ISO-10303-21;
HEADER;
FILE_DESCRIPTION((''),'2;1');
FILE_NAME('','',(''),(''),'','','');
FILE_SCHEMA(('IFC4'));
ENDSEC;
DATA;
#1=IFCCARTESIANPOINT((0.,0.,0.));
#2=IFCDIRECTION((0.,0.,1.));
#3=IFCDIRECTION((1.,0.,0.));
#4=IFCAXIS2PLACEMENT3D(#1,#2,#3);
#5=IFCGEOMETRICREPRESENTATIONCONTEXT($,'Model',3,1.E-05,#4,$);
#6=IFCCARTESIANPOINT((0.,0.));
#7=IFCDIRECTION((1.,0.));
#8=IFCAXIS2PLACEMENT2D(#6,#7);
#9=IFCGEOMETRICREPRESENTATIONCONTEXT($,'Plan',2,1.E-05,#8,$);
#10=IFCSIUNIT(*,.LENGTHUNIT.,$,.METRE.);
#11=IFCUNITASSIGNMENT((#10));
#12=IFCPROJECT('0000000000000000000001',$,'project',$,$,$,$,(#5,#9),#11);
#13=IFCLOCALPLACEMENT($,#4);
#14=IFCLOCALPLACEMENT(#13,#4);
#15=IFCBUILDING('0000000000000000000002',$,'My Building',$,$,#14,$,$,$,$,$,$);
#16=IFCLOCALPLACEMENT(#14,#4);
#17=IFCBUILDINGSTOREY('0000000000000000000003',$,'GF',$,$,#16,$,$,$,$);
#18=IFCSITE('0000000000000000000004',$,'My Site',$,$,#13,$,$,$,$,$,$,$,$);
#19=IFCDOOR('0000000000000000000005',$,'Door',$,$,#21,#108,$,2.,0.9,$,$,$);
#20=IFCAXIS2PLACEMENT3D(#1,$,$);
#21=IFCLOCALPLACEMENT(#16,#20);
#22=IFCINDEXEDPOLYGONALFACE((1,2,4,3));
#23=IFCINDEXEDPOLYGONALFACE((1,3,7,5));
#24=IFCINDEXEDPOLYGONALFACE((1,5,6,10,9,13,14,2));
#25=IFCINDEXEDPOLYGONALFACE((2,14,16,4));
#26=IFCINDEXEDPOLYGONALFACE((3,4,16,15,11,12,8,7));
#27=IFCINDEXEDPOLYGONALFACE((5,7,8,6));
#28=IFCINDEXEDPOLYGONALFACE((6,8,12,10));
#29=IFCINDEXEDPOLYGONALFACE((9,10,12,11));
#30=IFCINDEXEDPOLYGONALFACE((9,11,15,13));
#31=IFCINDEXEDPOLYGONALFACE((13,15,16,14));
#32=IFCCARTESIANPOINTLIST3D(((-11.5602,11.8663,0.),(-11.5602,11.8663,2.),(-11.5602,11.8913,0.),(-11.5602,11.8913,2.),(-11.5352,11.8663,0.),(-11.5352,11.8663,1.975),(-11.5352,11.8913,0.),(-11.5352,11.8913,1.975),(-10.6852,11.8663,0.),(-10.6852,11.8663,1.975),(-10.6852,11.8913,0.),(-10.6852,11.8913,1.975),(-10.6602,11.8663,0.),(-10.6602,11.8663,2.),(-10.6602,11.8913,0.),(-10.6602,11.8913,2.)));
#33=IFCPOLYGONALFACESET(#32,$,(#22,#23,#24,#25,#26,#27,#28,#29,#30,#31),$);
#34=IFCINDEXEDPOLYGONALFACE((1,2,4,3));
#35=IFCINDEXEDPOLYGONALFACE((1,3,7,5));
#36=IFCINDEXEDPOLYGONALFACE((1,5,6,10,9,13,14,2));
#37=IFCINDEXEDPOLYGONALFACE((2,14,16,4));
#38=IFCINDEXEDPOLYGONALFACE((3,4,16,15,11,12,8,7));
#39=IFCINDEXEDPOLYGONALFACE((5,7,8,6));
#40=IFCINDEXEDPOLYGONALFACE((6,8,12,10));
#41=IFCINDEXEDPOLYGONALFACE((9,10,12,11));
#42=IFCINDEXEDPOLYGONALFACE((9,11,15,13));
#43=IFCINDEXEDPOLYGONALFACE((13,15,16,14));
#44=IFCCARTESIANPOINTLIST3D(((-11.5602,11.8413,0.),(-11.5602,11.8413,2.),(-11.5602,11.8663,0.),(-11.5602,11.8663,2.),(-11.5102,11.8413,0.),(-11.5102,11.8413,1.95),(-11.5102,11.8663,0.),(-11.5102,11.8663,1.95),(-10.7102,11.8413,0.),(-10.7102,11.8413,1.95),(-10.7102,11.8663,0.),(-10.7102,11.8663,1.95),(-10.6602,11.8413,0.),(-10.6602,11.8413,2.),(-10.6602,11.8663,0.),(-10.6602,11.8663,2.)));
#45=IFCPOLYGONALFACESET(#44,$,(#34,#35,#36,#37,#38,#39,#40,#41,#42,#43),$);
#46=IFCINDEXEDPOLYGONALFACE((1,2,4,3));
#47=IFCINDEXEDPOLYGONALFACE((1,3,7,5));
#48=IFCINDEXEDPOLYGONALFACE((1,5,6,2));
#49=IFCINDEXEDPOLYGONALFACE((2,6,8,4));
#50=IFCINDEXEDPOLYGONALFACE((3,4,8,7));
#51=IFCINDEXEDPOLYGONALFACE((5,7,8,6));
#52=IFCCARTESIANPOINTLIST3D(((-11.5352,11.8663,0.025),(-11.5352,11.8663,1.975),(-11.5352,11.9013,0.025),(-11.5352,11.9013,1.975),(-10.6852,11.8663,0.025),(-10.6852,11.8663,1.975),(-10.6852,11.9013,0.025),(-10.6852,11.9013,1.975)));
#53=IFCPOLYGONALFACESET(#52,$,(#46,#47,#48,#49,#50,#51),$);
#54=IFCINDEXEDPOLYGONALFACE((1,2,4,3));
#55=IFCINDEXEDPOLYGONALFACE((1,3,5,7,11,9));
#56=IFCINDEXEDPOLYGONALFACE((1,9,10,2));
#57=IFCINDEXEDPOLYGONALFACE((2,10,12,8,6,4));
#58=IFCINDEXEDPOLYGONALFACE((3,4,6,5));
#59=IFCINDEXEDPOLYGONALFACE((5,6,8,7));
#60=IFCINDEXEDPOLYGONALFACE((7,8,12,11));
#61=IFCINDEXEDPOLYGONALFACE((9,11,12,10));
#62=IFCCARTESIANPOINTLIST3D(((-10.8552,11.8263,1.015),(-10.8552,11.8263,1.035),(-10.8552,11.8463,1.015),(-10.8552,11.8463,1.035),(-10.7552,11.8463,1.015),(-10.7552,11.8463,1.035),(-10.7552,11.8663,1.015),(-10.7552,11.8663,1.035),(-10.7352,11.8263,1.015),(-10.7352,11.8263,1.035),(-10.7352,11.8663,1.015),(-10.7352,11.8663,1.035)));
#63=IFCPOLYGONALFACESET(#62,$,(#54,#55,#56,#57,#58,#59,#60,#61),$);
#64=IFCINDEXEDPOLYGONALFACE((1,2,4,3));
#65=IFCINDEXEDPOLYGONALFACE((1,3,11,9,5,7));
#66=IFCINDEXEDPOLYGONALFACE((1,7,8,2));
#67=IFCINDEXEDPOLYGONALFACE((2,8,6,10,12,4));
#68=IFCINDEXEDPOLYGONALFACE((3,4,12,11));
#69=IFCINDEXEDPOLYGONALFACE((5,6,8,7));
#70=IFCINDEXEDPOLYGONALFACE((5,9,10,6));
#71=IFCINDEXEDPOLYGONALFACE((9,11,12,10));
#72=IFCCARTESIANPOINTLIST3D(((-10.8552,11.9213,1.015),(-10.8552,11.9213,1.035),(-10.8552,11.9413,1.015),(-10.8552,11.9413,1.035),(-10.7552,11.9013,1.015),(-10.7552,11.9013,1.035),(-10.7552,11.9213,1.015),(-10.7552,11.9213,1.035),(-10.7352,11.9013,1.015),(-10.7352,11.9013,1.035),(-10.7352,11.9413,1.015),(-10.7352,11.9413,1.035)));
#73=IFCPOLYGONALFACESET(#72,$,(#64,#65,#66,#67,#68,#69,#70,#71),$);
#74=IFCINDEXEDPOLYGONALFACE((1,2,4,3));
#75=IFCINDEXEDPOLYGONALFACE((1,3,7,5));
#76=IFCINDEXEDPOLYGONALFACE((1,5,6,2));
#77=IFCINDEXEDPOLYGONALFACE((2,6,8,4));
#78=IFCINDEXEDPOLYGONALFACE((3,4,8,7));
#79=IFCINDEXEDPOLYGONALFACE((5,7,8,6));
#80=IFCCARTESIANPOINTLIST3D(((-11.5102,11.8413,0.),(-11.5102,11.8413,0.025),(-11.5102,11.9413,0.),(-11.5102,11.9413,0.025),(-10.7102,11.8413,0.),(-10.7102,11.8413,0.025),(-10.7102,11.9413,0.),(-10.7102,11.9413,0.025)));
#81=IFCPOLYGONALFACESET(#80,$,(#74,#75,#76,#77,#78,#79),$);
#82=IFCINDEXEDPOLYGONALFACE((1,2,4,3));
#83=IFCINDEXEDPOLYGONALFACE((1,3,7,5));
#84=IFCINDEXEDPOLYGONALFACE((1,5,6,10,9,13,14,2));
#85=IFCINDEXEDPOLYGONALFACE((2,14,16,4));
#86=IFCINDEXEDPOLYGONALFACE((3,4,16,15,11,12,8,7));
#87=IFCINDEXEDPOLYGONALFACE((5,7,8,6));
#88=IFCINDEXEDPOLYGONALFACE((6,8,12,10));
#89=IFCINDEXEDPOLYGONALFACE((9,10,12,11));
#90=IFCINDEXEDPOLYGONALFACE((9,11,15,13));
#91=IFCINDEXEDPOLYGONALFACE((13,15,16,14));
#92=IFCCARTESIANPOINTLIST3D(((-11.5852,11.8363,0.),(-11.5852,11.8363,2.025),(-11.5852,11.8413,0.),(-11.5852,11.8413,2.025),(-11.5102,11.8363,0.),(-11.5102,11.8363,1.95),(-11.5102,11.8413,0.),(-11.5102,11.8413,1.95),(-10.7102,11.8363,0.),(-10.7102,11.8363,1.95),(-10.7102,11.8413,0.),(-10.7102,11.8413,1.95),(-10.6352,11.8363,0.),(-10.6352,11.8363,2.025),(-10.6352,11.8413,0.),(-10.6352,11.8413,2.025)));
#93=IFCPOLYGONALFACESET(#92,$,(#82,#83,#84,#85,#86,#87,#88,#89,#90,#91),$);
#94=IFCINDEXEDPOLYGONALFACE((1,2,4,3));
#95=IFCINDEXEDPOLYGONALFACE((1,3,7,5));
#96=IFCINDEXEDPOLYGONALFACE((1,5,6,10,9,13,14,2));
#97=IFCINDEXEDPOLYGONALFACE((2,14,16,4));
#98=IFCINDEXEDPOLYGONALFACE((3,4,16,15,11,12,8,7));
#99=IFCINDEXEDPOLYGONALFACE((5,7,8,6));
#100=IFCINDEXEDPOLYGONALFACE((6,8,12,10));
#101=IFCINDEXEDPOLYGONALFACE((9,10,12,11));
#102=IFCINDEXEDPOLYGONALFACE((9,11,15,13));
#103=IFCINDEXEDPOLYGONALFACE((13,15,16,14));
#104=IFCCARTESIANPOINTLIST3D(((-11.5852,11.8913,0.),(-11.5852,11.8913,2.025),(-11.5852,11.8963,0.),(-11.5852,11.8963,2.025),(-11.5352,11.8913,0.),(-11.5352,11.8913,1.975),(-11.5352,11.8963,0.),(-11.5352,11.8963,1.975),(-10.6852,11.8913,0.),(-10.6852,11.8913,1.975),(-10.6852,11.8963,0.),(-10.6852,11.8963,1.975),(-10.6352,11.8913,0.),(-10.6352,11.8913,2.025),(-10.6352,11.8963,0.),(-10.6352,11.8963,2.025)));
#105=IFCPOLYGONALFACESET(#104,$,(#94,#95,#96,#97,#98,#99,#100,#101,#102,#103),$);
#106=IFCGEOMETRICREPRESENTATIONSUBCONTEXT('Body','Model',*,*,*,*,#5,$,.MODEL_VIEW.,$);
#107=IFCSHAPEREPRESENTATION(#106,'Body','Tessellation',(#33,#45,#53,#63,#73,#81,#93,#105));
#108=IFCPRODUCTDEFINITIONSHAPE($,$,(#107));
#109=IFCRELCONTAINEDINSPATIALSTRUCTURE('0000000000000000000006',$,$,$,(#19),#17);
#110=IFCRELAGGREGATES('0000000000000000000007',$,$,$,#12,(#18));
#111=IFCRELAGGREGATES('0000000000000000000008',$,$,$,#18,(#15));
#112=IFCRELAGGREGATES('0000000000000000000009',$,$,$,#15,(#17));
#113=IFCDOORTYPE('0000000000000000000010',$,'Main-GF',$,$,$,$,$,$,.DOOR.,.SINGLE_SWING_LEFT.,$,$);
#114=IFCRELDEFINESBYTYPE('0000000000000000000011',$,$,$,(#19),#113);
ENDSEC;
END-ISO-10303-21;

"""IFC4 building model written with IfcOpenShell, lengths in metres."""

from ifc_helpers import new_model, entity, si_unit, frame, origin_with_axes, origin_2d_with_axis, place, context, subcontext, project, spatial, line, indexed_curve, outline, extrude, shape, source, transform, mapped, type_object, type_shapes, element, save


model = new_model("IFC4")

# Units and contexts
model_context = context("Model", 3, precision=1e-05, world=origin_with_axes())
plan_context = context("Plan", 2, precision=1e-05, world=origin_2d_with_axis())
body_context_1 = subcontext(model_context, "Body", "Model", "MODEL_VIEW")
body_context_2 = subcontext(plan_context, "Body", "Plan", "PLAN_VIEW")
ifc_project = project(units=[si_unit("LENGTHUNIT", "METRE")], contexts=[model_context, plan_context])

# Site, building, storey
site_placement = place(None, origin_with_axes())
site = spatial("IfcSite", under=ifc_project, at=site_placement, Name="My Site")
building_placement = place(site_placement, origin_with_axes())
building = spatial("IfcBuilding", under=site, at=building_placement, Name="My Building")
storey_placement = place(building_placement, origin_with_axes())
storey = spatial("IfcBuildingStorey", under=building, at=storey_placement, Name="GF")

# Door
door_type_1 = type_object("IfcDoorType", Name="Main-GF", OperationType="SINGLE_SWING_LEFT", PredefinedType="DOOR")
shared_shape_1 = source(origin_with_axes(), body_context_1, "Body", "SweptSolid", [
    extrude(outline(indexed_curve([(0.0, 0.0), (0.0, 2.0), (0.9, 2.0), (0.9, 0.0), (0.875, 0.0), (0.875, 1.975), (0.025, 1.975), (0.025, 0.0)], segments=[line(1, 2, 3, 4, 5, 6, 7, 8, 1)])), frame((0.0, 0.025, 0.0), z_axis=(0.0, -1.0, 0.0), x_axis=(1.0, 0.0, 0.0)), (0.0, 0.0, -1.0), 0.025),
    extrude(outline(indexed_curve([(0.0, 0.0), (0.0, 2.0), (0.9, 2.0), (0.9, 0.0), (0.85, 0.0), (0.85, 1.95), (0.05, 1.95), (0.05, 0.0)], segments=[line(1, 2, 3, 4, 5, 6, 7, 8, 1)])), frame((0.0, 0.0, 0.0), z_axis=(0.0, -1.0, 0.0), x_axis=(1.0, 0.0, 0.0)), (0.0, 0.0, -1.0), 0.025),
    extrude(outline(indexed_curve([(0.0, 0.0), (0.85, 0.0), (0.85, 0.035), (0.0, 0.035)], segments=[line(1, 2, 3, 4, 1)])), frame((0.025, 0.025, 0.025), z_axis=(0.0, 0.0, 1.0), x_axis=(1.0, 0.0, 0.0)), (0.0, 0.0, 1.0), 1.95),
    extrude(outline(indexed_curve([(0.0, 0.0), (0.0, -0.04), (-0.12, -0.04), (-0.12, -0.02), (-0.02, -0.02), (-0.02, 0.0)], segments=[line(1, 2, 3, 4, 5, 6, 1)])), frame((0.825, 0.025, 1.015), z_axis=(0.0, 0.0, 1.0), x_axis=(1.0, 0.0, 0.0)), (0.0, 0.0, 1.0), 0.02),
    extrude(outline(indexed_curve([(0.0, 0.0), (0.0, 0.04), (-0.12, 0.04), (-0.12, 0.02), (-0.02, 0.02), (-0.02, 0.0)], segments=[line(1, 2, 3, 4, 5, 6, 1)])), frame((0.825, 0.06, 1.015), z_axis=(0.0, 0.0, 1.0), x_axis=(1.0, 0.0, 0.0)), (0.0, 0.0, 1.0), 0.02),
    extrude(outline(indexed_curve([(0.0, 0.0), (0.8, 0.0), (0.8, 0.1), (0.0, 0.1)], segments=[line(1, 2, 3, 4, 1)])), frame((0.05, 0.0, 0.0), z_axis=(0.0, 0.0, 1.0), x_axis=(1.0, 0.0, 0.0)), (0.0, 0.0, 1.0), 0.025),
    extrude(outline(indexed_curve([(0.0, 0.0), (0.0, 2.025), (0.95, 2.025), (0.95, 0.0), (0.875, 0.0), (0.875, 1.95), (0.075, 1.95), (0.075, 0.0)], segments=[line(1, 2, 3, 4, 5, 6, 7, 8, 1)])), frame((-0.025, -0.005, 0.0), z_axis=(0.0, -1.0, 0.0), x_axis=(1.0, 0.0, 0.0)), (0.0, 0.0, -1.0), 0.005),
    extrude(outline(indexed_curve([(0.0, 0.0), (0.0, 2.025), (0.95, 2.025), (0.95, 0.0), (0.9, 0.0), (0.9, 1.975), (0.05, 1.975), (0.05, 0.0)], segments=[line(1, 2, 3, 4, 5, 6, 7, 8, 1)])), frame((-0.025, 0.05, 0.0), z_axis=(0.0, -1.0, 0.0), x_axis=(1.0, 0.0, 0.0)), (0.0, 0.0, -1.0), 0.005),
])
shared_shape_2 = source(origin_with_axes(), body_context_2, "Body", "Curve2D", [
    entity("IfcIndexedPolyCurve", entity("IfcCartesianPointList2D", [[0.0, 0.0], [0.0, 0.05], [0.025, 0.05], [0.025, 0.025], [0.05, 0.025], [0.05, 0.0]]), [entity("IfcLineIndex", [1, 2, 3, 4, 5, 6, 1])]),
    entity("IfcIndexedPolyCurve", entity("IfcCartesianPointList2D", [[0.9, 0.0], [0.9, 0.05], [0.875, 0.05], [0.875, 0.025], [0.85, 0.025], [0.85, 0.0]]), [entity("IfcLineIndex", [1, 2, 3, 4, 5, 6, 1])]),
    entity("IfcTrimmedCurve", entity("IfcEllipse", entity("IfcAxis2Placement2D", entity("IfcCartesianPoint", [0.06, 0.05]), entity("IfcDirection", [1.0, 0.0])), 0.815, 0.85), [entity("IfcCartesianPoint", [0.875, 0.05])], [entity("IfcCartesianPoint", [0.06, 0.9])], True, "CARTESIAN"),
    entity("IfcIndexedPolyCurve", entity("IfcCartesianPointList2D", [[0.025, 0.05], [0.06, 0.05], [0.06, 0.9], [0.025, 0.9]]), [entity("IfcLineIndex", [1, 2, 3, 4, 1])]),
])
type_shapes(door_type_1, [shared_shape_1, shared_shape_2])
door_1_placement = place(storey_placement, frame((-11.5602, 11.8413, 0.0), z_axis=(0.0, 0.0, 1.0), x_axis=(1.0, 0.0, 0.0)))
element("IfcDoor", 1, at=door_1_placement, inside=storey, type_object=door_type_1, Name="Door", OverallHeight=2.0, OverallWidth=0.9, shapes=[
    shape(body_context_1, "Body", "MappedRepresentation", [mapped(shared_shape_1, transform((0.0, 0.0, 0.0), x_axis=(1.0, 0.0, 0.0), y_axis=(0.0, 1.0, 0.0), z_axis=(0.0, 0.0, 1.0), scale=1.0))]),
    shape(body_context_2, "Body", "MappedRepresentation", [mapped(shared_shape_2, transform((0.0, 0.0, 0.0), x_axis=(1.0, 0.0, 0.0), y_axis=(0.0, 1.0, 0.0), z_axis=(0.0, 0.0, 1.0), scale=1.0))]),
])

save(model, "model.ifc")
